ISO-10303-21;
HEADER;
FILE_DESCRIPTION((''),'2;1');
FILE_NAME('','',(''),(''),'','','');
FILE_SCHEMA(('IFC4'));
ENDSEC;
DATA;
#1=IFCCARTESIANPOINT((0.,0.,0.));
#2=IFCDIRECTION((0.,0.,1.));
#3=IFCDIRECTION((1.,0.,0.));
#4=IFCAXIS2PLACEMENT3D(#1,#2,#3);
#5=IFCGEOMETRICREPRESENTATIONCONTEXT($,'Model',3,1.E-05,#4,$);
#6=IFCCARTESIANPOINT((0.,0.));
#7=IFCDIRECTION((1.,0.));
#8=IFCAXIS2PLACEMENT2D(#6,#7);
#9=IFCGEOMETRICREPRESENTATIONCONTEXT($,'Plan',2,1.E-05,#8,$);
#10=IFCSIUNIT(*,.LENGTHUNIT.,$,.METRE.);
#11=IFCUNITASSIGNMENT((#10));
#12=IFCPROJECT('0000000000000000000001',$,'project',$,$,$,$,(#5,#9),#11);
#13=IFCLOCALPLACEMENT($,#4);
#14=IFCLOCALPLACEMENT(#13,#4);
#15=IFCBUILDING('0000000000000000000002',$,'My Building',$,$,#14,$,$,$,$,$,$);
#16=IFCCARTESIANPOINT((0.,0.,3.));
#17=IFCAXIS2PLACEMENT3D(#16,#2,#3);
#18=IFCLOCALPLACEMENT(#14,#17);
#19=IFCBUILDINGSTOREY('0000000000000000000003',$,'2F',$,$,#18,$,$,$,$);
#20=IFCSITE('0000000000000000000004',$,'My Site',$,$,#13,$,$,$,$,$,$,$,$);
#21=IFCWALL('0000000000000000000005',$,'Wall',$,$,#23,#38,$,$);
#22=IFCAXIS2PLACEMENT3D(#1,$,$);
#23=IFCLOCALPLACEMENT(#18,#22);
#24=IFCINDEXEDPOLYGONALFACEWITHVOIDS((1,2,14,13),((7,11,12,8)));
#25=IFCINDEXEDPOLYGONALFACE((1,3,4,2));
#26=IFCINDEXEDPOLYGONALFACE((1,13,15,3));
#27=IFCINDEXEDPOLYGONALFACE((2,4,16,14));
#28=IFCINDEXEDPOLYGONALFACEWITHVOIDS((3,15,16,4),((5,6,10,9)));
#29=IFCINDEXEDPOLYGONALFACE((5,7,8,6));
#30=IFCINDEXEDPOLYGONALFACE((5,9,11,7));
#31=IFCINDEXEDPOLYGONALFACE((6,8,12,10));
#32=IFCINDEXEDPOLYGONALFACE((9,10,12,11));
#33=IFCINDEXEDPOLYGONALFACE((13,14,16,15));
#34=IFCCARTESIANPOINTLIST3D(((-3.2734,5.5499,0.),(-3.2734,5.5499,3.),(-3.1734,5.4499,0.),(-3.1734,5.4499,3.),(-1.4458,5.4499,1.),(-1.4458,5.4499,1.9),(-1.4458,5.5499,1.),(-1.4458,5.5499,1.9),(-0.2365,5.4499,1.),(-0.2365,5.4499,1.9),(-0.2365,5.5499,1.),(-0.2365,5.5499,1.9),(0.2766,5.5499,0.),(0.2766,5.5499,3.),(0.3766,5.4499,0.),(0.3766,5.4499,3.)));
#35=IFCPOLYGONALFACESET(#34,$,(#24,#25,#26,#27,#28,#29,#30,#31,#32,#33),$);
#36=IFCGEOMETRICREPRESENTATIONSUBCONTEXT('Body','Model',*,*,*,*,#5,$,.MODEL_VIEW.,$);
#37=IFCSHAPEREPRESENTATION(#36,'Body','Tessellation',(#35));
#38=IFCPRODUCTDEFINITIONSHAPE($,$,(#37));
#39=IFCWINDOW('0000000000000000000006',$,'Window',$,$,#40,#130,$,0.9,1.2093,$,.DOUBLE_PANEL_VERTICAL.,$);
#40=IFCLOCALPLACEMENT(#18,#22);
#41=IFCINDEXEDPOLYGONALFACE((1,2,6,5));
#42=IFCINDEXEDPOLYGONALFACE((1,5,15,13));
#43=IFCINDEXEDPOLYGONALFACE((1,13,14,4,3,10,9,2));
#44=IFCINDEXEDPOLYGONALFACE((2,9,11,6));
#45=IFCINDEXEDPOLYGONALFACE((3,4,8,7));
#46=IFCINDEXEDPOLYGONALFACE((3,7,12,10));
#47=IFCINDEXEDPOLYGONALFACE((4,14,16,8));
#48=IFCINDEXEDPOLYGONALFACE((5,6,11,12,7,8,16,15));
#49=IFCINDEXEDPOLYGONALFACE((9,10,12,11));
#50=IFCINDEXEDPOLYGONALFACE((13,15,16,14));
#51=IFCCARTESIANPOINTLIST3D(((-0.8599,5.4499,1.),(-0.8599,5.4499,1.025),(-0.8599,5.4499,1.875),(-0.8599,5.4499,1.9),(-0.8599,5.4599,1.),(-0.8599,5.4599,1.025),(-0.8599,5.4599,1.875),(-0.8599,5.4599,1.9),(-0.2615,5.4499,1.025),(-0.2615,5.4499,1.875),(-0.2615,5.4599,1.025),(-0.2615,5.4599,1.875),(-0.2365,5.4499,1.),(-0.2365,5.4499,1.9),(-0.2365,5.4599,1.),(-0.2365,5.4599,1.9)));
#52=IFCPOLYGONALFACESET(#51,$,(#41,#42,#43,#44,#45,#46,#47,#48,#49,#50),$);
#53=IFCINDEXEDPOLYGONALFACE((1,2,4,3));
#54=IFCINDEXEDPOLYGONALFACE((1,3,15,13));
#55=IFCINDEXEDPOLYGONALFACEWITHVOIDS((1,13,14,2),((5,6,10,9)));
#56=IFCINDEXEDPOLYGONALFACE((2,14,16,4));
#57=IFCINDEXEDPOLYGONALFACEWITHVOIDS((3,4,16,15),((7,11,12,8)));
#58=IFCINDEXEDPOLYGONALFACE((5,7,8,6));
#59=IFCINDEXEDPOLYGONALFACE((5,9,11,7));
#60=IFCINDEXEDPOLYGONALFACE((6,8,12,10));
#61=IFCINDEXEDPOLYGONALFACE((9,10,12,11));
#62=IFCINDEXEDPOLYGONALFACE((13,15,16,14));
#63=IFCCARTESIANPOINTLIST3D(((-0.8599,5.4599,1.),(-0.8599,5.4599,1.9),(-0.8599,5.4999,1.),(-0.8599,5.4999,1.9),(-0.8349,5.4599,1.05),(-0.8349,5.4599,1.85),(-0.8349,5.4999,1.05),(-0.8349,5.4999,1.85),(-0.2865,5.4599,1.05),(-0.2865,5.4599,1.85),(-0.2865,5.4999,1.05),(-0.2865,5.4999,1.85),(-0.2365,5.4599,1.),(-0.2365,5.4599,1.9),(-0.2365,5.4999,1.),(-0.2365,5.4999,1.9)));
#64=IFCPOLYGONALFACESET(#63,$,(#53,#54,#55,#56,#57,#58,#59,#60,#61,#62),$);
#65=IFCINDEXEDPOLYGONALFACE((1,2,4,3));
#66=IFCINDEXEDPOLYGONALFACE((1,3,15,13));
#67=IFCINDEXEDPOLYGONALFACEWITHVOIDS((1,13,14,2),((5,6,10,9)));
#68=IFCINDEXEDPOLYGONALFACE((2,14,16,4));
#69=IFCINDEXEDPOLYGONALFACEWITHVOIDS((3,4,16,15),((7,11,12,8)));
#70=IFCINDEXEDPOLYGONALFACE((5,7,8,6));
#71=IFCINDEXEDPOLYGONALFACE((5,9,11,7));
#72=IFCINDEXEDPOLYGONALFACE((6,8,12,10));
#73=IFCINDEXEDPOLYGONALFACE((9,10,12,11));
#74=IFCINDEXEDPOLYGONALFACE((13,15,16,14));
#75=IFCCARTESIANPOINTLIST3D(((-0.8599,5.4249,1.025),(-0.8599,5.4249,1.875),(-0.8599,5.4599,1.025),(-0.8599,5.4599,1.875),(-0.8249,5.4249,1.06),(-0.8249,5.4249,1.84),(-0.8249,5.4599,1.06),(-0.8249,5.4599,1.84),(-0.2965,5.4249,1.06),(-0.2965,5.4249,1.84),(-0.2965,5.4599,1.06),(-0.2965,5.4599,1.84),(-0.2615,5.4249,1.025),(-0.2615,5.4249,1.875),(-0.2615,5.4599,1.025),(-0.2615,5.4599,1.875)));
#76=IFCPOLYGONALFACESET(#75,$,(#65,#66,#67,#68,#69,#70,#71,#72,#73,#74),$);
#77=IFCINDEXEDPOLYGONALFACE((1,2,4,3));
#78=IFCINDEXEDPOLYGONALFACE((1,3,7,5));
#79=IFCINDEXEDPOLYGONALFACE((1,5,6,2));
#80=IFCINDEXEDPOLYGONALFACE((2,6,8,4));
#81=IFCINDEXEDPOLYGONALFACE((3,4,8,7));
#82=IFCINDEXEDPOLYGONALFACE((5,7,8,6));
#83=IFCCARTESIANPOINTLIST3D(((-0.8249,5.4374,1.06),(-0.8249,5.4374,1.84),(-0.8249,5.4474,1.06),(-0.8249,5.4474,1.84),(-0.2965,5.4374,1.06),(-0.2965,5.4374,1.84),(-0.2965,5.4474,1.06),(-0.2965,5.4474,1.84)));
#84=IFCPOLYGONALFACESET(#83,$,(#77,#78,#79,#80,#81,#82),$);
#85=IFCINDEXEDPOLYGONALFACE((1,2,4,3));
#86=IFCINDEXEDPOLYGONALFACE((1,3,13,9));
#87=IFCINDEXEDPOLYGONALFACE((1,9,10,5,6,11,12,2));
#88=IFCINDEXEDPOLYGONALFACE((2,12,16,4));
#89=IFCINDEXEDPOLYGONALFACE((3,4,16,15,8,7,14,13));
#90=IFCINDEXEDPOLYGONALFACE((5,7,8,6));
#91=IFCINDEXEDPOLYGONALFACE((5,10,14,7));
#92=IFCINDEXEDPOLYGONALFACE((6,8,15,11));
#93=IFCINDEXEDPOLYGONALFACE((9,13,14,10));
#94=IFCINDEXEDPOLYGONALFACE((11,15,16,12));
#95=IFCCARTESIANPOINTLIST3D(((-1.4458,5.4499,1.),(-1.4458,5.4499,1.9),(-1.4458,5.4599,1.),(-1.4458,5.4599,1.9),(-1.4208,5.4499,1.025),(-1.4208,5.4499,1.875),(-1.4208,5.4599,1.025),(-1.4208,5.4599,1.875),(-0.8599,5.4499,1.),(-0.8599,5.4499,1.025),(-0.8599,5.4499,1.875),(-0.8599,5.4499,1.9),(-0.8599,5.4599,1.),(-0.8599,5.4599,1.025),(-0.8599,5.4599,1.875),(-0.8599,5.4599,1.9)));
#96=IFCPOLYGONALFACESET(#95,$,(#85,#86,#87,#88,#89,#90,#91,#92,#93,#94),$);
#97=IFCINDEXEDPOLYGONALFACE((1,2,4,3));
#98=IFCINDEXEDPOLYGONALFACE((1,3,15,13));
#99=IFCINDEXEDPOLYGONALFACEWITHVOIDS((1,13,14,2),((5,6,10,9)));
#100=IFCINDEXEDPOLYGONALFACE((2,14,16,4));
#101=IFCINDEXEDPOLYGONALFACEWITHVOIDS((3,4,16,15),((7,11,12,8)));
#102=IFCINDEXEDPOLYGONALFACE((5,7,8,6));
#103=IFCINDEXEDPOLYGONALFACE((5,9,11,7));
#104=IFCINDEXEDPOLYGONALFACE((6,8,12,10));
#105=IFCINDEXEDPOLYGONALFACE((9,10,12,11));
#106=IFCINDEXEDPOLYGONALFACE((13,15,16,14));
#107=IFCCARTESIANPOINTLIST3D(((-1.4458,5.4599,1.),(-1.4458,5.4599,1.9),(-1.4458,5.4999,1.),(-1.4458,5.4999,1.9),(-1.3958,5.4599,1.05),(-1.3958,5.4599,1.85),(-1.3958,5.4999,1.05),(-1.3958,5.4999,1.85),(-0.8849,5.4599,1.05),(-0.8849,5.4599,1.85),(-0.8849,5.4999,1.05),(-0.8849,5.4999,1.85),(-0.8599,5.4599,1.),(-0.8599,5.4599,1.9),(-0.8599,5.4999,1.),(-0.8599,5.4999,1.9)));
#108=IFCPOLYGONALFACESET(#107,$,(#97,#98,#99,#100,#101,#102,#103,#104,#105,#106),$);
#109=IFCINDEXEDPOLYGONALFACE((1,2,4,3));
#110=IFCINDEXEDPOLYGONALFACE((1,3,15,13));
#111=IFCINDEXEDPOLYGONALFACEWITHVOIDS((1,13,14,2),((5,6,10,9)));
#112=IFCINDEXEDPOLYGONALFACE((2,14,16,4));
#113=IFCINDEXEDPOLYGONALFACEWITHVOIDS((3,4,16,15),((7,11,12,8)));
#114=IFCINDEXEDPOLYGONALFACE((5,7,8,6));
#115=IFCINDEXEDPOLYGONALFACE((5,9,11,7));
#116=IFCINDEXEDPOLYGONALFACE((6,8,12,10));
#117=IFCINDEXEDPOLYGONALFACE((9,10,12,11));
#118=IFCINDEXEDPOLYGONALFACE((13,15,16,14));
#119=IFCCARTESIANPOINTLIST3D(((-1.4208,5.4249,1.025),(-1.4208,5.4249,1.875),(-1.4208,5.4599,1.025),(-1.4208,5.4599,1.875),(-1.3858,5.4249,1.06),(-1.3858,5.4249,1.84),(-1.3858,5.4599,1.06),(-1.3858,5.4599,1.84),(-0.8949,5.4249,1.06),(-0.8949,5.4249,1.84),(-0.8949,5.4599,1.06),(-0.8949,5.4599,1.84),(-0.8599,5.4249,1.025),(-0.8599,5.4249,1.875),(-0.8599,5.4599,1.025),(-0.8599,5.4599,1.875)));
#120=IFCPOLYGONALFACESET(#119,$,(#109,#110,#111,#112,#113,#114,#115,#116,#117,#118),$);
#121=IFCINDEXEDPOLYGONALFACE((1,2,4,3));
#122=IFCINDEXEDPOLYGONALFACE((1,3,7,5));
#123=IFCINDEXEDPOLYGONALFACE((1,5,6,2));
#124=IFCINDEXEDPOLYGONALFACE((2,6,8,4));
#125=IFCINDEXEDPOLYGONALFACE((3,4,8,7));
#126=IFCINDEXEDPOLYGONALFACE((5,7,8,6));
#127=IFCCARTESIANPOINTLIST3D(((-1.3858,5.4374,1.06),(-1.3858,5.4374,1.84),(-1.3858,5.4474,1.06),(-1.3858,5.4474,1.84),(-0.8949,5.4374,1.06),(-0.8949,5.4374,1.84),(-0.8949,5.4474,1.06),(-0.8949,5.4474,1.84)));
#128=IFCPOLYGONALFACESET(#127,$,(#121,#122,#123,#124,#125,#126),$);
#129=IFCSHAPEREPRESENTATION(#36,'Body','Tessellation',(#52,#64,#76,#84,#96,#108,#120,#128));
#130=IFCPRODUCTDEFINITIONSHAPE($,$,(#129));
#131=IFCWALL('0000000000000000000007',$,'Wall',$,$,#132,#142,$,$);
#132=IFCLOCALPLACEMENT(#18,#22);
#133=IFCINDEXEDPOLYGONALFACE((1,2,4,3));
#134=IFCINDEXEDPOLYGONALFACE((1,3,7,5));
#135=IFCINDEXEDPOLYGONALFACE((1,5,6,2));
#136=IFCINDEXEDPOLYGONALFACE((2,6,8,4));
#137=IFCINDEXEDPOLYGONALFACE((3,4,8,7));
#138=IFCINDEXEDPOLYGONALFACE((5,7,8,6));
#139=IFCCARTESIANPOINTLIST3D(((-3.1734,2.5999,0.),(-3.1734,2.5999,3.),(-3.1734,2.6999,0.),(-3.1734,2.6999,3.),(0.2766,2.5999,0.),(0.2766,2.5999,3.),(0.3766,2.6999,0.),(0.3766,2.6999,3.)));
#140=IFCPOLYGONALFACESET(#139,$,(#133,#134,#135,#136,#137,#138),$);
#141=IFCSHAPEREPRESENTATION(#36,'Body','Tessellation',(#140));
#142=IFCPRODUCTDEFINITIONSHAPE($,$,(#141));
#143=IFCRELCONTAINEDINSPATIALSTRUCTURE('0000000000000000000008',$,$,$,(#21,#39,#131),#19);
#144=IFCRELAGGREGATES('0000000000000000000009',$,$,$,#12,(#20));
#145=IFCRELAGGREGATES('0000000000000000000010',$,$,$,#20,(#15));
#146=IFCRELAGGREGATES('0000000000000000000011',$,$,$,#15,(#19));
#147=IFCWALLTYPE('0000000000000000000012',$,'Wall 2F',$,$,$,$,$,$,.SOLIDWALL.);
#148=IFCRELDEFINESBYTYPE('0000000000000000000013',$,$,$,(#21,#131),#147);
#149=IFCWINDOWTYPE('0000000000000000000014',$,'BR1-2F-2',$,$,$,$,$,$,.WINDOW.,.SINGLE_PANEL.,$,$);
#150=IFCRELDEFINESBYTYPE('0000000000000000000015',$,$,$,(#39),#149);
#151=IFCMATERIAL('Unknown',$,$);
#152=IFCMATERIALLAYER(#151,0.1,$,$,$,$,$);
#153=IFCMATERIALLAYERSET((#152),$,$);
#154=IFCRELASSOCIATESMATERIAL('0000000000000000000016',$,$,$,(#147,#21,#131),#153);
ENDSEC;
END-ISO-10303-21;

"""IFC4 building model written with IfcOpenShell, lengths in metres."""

from ifc_helpers import new_model, entity, si_unit, frame, origin_with_axes, origin_2d_with_axis, place, context, subcontext, project, spatial, line, indexed_curve, outline, extrude, shape, source, transform, mapped, material, layer, layer_set, layer_usage, type_object, type_shapes, element, fill, save


model = new_model("IFC4")

# Units and contexts
model_context = context("Model", 3, precision=1e-05, world=origin_with_axes())
plan_context = context("Plan", 2, precision=1e-05, world=origin_2d_with_axis())
body_context_1 = subcontext(model_context, "Body", "Model", "MODEL_VIEW")
body_context_2 = subcontext(plan_context, "Body", "Plan", "PLAN_VIEW")
ifc_project = project(units=[si_unit("LENGTHUNIT", "METRE")], contexts=[model_context, plan_context])

# Site, building, storey
site_placement = place(None, origin_with_axes())
site = spatial("IfcSite", under=ifc_project, at=site_placement, Name="My Site")
building_placement = place(site_placement, origin_with_axes())
building = spatial("IfcBuilding", under=site, at=building_placement, Name="My Building")
storey_placement = place(building_placement, frame((0.0, 0.0, 3.0), z_axis=(0.0, 0.0, 1.0), x_axis=(1.0, 0.0, 0.0)))
storey = spatial("IfcBuildingStorey", under=building, at=storey_placement, Name="2F")

# Shared definitions
ifc_material = material(Name="Unknown")

# Shared definitions
ifc_layer = layer(ifc_material, 0.1)
ifc_layer_set = layer_set([ifc_layer])
wall_type = type_object("IfcWallType", Name="Wall 2F", PredefinedType="SOLIDWALL", material=ifc_layer_set)

# Wall, opening, window
ifc_layer_usage_1 = layer_usage(ifc_layer_set, "AXIS2", "POSITIVE", 0.0)
wall_1_placement = place(storey_placement, frame((0.2766, 5.5499, 0.0), z_axis=(0.0, 0.0, 1.0), x_axis=(-1.0, 0.0, 0.0)))
wall_1 = element("IfcWall", 1, at=wall_1_placement, inside=storey, type_object=wall_type, material=ifc_layer_usage_1, Name="Wall", context=body_context_1, shape_type="SweptSolid", body=[
    extrude(outline(indexed_curve([(0.0, 0.0), (-0.1, 0.1), (3.45, 0.1), (3.55, 0.0)], segments=[line(1, 2, 3, 4, 1)])), origin_with_axes(), (0.0, 0.0, 1.0), 3.0),
])
shared_shape_1 = source(origin_with_axes(), body_context_1, "Body", "SweptSolid", [
    extrude(outline(indexed_curve([(0.0, 0.0), (1.2093, 0.0), (1.2093, 0.9), (0.0, 0.9)], segments=[line(1, 2, 3, 4, 1)])), frame((0.0, -0.6, 0.0), z_axis=(0.0, -1.0, 0.0), x_axis=(1.0, 0.0, 0.0)), (0.0, 0.0, -1.0), 1.2),
])
opening_1_placement = place(wall_1_placement, frame((0.5131, 0.0, 1.0), z_axis=(0.0, 0.0, 1.0), x_axis=(1.0, 0.0, 0.0)))
opening_1 = element("IfcOpeningElement", 2, at=opening_1_placement, cuts=wall_1, PredefinedType="OPENING", context=body_context_1, shape_type="MappedRepresentation", body=[
    mapped(shared_shape_1, transform((0.0, 0.0, 0.0), x_axis=(1.0, 0.0, 0.0), y_axis=(0.0, 1.0, 0.0), z_axis=(0.0, 0.0, 1.0), scale=1.0)),
])
window_type_1 = type_object("IfcWindowType", Name="BR1-2F-2", PartitioningType="SINGLE_PANEL", PredefinedType="WINDOW")
shared_shape_2 = source(origin_with_axes(), body_context_1, "Body", "SweptSolid", [
    extrude(outline(indexed_curve([(0.6234, 0.0), (0.0, 0.0), (0.0, 0.9), (0.6234, 0.9), (0.6234, 0.875), (0.025, 0.875), (0.025, 0.025), (0.6234, 0.025)], segments=[line(1, 2, 3, 4, 5, 6, 7, 8, 1)])), frame((0.0, 0.09, 0.0), z_axis=(0.0, -1.0, 0.0), x_axis=(1.0, 0.0, 0.0)), (0.0, 0.0, -1.0), 0.01),
    extrude(outline(indexed_curve([(0.0, 0.0), (0.6234, 0.0), (0.6234, 0.9), (0.0, 0.9)], segments=[line(1, 2, 3, 4, 1)]), holes=[indexed_curve([(0.05, 0.05), (0.5984, 0.05), (0.5984, 0.85), (0.05, 0.85)], segments=[line(1, 2, 3, 4, 1)])]), frame((0.0, 0.05, 0.0), z_axis=(0.0, -1.0, 0.0), x_axis=(1.0, 0.0, 0.0)), (0.0, 0.0, -1.0), 0.04),
    extrude(outline(indexed_curve([(0.0, 0.0), (0.5984, 0.0), (0.5984, 0.85), (0.0, 0.85)], segments=[line(1, 2, 3, 4, 1)]), holes=[indexed_curve([(0.035, 0.035), (0.5634, 0.035), (0.5634, 0.815), (0.035, 0.815)], segments=[line(1, 2, 3, 4, 1)])]), frame((0.025, 0.09, 0.025), z_axis=(0.0, -1.0, 0.0), x_axis=(1.0, 0.0, 0.0)), (0.0, 0.0, -1.0), 0.035),
    extrude(outline(indexed_curve([(0.035, 0.035), (0.5634, 0.035), (0.5634, 0.815), (0.035, 0.815)], segments=[line(1, 2, 3, 4, 1)])), frame((0.025, 0.1025, 0.025), z_axis=(0.0, -1.0, 0.0), x_axis=(1.0, 0.0, 0.0)), (0.0, 0.0, -1.0), 0.01),
    extrude(outline(indexed_curve([(0.0, 0.9), (0.5859, 0.9), (0.5859, 0.0), (0.0, 0.0), (0.0, 0.025), (0.5609, 0.025), (0.5609, 0.875), (0.0, 0.875)], segments=[line(1, 2, 3, 4, 5, 6, 7, 8, 1)])), frame((0.6234, 0.09, 0.0), z_axis=(0.0, -1.0, 0.0), x_axis=(1.0, 0.0, 0.0)), (0.0, 0.0, -1.0), 0.01),
    extrude(outline(indexed_curve([(0.0, 0.0), (0.5859, 0.0), (0.5859, 0.9), (0.0, 0.9)], segments=[line(1, 2, 3, 4, 1)]), holes=[indexed_curve([(0.025, 0.05), (0.5359, 0.05), (0.5359, 0.85), (0.025, 0.85)], segments=[line(1, 2, 3, 4, 1)])]), frame((0.6234, 0.05, 0.0), z_axis=(0.0, -1.0, 0.0), x_axis=(1.0, 0.0, 0.0)), (0.0, 0.0, -1.0), 0.04),
    extrude(outline(indexed_curve([(0.0, 0.0), (0.5609, 0.0), (0.5609, 0.85), (0.0, 0.85)], segments=[line(1, 2, 3, 4, 1)]), holes=[indexed_curve([(0.035, 0.035), (0.5259, 0.035), (0.5259, 0.815), (0.035, 0.815)], segments=[line(1, 2, 3, 4, 1)])]), frame((0.6234, 0.09, 0.025), z_axis=(0.0, -1.0, 0.0), x_axis=(1.0, 0.0, 0.0)), (0.0, 0.0, -1.0), 0.035),
    extrude(outline(indexed_curve([(0.035, 0.035), (0.5259, 0.035), (0.5259, 0.815), (0.035, 0.815)], segments=[line(1, 2, 3, 4, 1)])), frame((0.6234, 0.1025, 0.025), z_axis=(0.0, -1.0, 0.0), x_axis=(1.0, 0.0, 0.0)), (0.0, 0.0, -1.0), 0.01),
])
shared_shape_3 = source(origin_with_axes(), body_context_2, "Body", "Curve2D", [
    entity("IfcIndexedPolyCurve", entity("IfcCartesianPointList2D", [[0.05, 0.05], [0.5984, 0.05]])),
    entity("IfcIndexedPolyCurve", entity("IfcCartesianPointList2D", [[0.0, 0.1], [0.025, 0.1], [0.025, 0.09], [0.05, 0.09], [0.05, 0.05], [0.0, 0.05]]), [entity("IfcLineIndex", [1, 2, 3, 4, 5, 6, 1])]),
    entity("IfcIndexedPolyCurve", entity("IfcCartesianPointList2D", [[0.6234, 0.1], [0.6234, 0.1], [0.6234, 0.09], [0.5984, 0.09], [0.5984, 0.05], [0.6234, 0.05]])),
    entity("IfcIndexedPolyCurve", entity("IfcCartesianPointList2D", [[0.025, 0.09], [0.06, 0.09], [0.06, 0.125], [0.025, 0.125]]), [entity("IfcLineIndex", [1, 2, 3, 4, 1])]),
    entity("IfcIndexedPolyCurve", entity("IfcCartesianPointList2D", [[0.6234, 0.09], [0.5884, 0.09], [0.5884, 0.125], [0.6234, 0.125]]), [entity("IfcLineIndex", [1, 2, 3, 4, 1])]),
    entity("IfcIndexedPolyCurve", entity("IfcCartesianPointList2D", [[0.06, 0.09], [0.5884, 0.09]])),
    entity("IfcIndexedPolyCurve", entity("IfcCartesianPointList2D", [[0.06, 0.125], [0.5884, 0.125]])),
    entity("IfcIndexedPolyCurve", entity("IfcCartesianPointList2D", [[0.06, 0.1075], [0.5884, 0.1075]])),
    entity("IfcIndexedPolyCurve", entity("IfcCartesianPointList2D", [[0.6484, 0.05], [1.1593, 0.05]])),
    entity("IfcIndexedPolyCurve", entity("IfcCartesianPointList2D", [[0.6234, 0.1], [0.6234, 0.1], [0.6234, 0.09], [0.6484, 0.09], [0.6484, 0.05], [0.6234, 0.05]])),
    entity("IfcIndexedPolyCurve", entity("IfcCartesianPointList2D", [[1.2093, 0.1], [1.1843, 0.1], [1.1843, 0.09], [1.1593, 0.09], [1.1593, 0.05], [1.2093, 0.05]]), [entity("IfcLineIndex", [1, 2, 3, 4, 5, 6, 1])]),
    entity("IfcIndexedPolyCurve", entity("IfcCartesianPointList2D", [[0.6234, 0.09], [0.6584, 0.09], [0.6584, 0.125], [0.6234, 0.125]]), [entity("IfcLineIndex", [1, 2, 3, 4, 1])]),
    entity("IfcIndexedPolyCurve", entity("IfcCartesianPointList2D", [[1.1843, 0.09], [1.1493, 0.09], [1.1493, 0.125], [1.1843, 0.125]]), [entity("IfcLineIndex", [1, 2, 3, 4, 1])]),
    entity("IfcIndexedPolyCurve", entity("IfcCartesianPointList2D", [[0.6584, 0.09], [1.1493, 0.09]])),
    entity("IfcIndexedPolyCurve", entity("IfcCartesianPointList2D", [[0.6584, 0.125], [1.1493, 0.125]])),
    entity("IfcIndexedPolyCurve", entity("IfcCartesianPointList2D", [[0.6584, 0.1075], [1.1493, 0.1075]])),
])
type_shapes(window_type_1, [shared_shape_2, shared_shape_3])
window_1_placement = place(opening_1_placement, frame((0.0, 0.0, 0.0), z_axis=(0.0, 0.0, 1.0), x_axis=(1.0, 0.0, 0.0)))
window_1 = element("IfcWindow", 3, at=window_1_placement, inside=storey, type_object=window_type_1, Name="Window", OverallHeight=0.9, OverallWidth=1.2093, PartitioningType="DOUBLE_PANEL_VERTICAL", shapes=[
    shape(body_context_1, "Body", "MappedRepresentation", [mapped(shared_shape_2, transform((0.0, 0.0, 0.0), x_axis=(1.0, 0.0, 0.0), y_axis=(0.0, 1.0, 0.0), z_axis=(0.0, 0.0, 1.0), scale=1.0))]),
    shape(body_context_2, "Body", "MappedRepresentation", [mapped(shared_shape_3, transform((0.0, 0.0, 0.0), x_axis=(1.0, 0.0, 0.0), y_axis=(0.0, 1.0, 0.0), z_axis=(0.0, 0.0, 1.0), scale=1.0))]),
])
fill(opening_1, window_1)

# Wall
ifc_layer_usage_2 = layer_usage(ifc_layer_set, "AXIS2", "POSITIVE", 0.0)
wall_2_placement = place(storey_placement, frame((0.3766, 2.6999, 0.0), z_axis=(0.0, 0.0, 1.0), x_axis=(-1.0, 0.0, 0.0)))
element("IfcWall", 4, at=wall_2_placement, inside=storey, type_object=wall_type, material=ifc_layer_usage_2, Name="Wall", context=body_context_1, shape_type="SweptSolid", body=[
    extrude(outline(indexed_curve([(0.0, 0.0), (0.1, 0.1), (3.55, 0.1), (3.55, 0.0)], segments=[line(1, 2, 3, 4, 1)])), origin_with_axes(), (0.0, 0.0, 1.0), 3.0),
])

save(model, "model.ifc")
